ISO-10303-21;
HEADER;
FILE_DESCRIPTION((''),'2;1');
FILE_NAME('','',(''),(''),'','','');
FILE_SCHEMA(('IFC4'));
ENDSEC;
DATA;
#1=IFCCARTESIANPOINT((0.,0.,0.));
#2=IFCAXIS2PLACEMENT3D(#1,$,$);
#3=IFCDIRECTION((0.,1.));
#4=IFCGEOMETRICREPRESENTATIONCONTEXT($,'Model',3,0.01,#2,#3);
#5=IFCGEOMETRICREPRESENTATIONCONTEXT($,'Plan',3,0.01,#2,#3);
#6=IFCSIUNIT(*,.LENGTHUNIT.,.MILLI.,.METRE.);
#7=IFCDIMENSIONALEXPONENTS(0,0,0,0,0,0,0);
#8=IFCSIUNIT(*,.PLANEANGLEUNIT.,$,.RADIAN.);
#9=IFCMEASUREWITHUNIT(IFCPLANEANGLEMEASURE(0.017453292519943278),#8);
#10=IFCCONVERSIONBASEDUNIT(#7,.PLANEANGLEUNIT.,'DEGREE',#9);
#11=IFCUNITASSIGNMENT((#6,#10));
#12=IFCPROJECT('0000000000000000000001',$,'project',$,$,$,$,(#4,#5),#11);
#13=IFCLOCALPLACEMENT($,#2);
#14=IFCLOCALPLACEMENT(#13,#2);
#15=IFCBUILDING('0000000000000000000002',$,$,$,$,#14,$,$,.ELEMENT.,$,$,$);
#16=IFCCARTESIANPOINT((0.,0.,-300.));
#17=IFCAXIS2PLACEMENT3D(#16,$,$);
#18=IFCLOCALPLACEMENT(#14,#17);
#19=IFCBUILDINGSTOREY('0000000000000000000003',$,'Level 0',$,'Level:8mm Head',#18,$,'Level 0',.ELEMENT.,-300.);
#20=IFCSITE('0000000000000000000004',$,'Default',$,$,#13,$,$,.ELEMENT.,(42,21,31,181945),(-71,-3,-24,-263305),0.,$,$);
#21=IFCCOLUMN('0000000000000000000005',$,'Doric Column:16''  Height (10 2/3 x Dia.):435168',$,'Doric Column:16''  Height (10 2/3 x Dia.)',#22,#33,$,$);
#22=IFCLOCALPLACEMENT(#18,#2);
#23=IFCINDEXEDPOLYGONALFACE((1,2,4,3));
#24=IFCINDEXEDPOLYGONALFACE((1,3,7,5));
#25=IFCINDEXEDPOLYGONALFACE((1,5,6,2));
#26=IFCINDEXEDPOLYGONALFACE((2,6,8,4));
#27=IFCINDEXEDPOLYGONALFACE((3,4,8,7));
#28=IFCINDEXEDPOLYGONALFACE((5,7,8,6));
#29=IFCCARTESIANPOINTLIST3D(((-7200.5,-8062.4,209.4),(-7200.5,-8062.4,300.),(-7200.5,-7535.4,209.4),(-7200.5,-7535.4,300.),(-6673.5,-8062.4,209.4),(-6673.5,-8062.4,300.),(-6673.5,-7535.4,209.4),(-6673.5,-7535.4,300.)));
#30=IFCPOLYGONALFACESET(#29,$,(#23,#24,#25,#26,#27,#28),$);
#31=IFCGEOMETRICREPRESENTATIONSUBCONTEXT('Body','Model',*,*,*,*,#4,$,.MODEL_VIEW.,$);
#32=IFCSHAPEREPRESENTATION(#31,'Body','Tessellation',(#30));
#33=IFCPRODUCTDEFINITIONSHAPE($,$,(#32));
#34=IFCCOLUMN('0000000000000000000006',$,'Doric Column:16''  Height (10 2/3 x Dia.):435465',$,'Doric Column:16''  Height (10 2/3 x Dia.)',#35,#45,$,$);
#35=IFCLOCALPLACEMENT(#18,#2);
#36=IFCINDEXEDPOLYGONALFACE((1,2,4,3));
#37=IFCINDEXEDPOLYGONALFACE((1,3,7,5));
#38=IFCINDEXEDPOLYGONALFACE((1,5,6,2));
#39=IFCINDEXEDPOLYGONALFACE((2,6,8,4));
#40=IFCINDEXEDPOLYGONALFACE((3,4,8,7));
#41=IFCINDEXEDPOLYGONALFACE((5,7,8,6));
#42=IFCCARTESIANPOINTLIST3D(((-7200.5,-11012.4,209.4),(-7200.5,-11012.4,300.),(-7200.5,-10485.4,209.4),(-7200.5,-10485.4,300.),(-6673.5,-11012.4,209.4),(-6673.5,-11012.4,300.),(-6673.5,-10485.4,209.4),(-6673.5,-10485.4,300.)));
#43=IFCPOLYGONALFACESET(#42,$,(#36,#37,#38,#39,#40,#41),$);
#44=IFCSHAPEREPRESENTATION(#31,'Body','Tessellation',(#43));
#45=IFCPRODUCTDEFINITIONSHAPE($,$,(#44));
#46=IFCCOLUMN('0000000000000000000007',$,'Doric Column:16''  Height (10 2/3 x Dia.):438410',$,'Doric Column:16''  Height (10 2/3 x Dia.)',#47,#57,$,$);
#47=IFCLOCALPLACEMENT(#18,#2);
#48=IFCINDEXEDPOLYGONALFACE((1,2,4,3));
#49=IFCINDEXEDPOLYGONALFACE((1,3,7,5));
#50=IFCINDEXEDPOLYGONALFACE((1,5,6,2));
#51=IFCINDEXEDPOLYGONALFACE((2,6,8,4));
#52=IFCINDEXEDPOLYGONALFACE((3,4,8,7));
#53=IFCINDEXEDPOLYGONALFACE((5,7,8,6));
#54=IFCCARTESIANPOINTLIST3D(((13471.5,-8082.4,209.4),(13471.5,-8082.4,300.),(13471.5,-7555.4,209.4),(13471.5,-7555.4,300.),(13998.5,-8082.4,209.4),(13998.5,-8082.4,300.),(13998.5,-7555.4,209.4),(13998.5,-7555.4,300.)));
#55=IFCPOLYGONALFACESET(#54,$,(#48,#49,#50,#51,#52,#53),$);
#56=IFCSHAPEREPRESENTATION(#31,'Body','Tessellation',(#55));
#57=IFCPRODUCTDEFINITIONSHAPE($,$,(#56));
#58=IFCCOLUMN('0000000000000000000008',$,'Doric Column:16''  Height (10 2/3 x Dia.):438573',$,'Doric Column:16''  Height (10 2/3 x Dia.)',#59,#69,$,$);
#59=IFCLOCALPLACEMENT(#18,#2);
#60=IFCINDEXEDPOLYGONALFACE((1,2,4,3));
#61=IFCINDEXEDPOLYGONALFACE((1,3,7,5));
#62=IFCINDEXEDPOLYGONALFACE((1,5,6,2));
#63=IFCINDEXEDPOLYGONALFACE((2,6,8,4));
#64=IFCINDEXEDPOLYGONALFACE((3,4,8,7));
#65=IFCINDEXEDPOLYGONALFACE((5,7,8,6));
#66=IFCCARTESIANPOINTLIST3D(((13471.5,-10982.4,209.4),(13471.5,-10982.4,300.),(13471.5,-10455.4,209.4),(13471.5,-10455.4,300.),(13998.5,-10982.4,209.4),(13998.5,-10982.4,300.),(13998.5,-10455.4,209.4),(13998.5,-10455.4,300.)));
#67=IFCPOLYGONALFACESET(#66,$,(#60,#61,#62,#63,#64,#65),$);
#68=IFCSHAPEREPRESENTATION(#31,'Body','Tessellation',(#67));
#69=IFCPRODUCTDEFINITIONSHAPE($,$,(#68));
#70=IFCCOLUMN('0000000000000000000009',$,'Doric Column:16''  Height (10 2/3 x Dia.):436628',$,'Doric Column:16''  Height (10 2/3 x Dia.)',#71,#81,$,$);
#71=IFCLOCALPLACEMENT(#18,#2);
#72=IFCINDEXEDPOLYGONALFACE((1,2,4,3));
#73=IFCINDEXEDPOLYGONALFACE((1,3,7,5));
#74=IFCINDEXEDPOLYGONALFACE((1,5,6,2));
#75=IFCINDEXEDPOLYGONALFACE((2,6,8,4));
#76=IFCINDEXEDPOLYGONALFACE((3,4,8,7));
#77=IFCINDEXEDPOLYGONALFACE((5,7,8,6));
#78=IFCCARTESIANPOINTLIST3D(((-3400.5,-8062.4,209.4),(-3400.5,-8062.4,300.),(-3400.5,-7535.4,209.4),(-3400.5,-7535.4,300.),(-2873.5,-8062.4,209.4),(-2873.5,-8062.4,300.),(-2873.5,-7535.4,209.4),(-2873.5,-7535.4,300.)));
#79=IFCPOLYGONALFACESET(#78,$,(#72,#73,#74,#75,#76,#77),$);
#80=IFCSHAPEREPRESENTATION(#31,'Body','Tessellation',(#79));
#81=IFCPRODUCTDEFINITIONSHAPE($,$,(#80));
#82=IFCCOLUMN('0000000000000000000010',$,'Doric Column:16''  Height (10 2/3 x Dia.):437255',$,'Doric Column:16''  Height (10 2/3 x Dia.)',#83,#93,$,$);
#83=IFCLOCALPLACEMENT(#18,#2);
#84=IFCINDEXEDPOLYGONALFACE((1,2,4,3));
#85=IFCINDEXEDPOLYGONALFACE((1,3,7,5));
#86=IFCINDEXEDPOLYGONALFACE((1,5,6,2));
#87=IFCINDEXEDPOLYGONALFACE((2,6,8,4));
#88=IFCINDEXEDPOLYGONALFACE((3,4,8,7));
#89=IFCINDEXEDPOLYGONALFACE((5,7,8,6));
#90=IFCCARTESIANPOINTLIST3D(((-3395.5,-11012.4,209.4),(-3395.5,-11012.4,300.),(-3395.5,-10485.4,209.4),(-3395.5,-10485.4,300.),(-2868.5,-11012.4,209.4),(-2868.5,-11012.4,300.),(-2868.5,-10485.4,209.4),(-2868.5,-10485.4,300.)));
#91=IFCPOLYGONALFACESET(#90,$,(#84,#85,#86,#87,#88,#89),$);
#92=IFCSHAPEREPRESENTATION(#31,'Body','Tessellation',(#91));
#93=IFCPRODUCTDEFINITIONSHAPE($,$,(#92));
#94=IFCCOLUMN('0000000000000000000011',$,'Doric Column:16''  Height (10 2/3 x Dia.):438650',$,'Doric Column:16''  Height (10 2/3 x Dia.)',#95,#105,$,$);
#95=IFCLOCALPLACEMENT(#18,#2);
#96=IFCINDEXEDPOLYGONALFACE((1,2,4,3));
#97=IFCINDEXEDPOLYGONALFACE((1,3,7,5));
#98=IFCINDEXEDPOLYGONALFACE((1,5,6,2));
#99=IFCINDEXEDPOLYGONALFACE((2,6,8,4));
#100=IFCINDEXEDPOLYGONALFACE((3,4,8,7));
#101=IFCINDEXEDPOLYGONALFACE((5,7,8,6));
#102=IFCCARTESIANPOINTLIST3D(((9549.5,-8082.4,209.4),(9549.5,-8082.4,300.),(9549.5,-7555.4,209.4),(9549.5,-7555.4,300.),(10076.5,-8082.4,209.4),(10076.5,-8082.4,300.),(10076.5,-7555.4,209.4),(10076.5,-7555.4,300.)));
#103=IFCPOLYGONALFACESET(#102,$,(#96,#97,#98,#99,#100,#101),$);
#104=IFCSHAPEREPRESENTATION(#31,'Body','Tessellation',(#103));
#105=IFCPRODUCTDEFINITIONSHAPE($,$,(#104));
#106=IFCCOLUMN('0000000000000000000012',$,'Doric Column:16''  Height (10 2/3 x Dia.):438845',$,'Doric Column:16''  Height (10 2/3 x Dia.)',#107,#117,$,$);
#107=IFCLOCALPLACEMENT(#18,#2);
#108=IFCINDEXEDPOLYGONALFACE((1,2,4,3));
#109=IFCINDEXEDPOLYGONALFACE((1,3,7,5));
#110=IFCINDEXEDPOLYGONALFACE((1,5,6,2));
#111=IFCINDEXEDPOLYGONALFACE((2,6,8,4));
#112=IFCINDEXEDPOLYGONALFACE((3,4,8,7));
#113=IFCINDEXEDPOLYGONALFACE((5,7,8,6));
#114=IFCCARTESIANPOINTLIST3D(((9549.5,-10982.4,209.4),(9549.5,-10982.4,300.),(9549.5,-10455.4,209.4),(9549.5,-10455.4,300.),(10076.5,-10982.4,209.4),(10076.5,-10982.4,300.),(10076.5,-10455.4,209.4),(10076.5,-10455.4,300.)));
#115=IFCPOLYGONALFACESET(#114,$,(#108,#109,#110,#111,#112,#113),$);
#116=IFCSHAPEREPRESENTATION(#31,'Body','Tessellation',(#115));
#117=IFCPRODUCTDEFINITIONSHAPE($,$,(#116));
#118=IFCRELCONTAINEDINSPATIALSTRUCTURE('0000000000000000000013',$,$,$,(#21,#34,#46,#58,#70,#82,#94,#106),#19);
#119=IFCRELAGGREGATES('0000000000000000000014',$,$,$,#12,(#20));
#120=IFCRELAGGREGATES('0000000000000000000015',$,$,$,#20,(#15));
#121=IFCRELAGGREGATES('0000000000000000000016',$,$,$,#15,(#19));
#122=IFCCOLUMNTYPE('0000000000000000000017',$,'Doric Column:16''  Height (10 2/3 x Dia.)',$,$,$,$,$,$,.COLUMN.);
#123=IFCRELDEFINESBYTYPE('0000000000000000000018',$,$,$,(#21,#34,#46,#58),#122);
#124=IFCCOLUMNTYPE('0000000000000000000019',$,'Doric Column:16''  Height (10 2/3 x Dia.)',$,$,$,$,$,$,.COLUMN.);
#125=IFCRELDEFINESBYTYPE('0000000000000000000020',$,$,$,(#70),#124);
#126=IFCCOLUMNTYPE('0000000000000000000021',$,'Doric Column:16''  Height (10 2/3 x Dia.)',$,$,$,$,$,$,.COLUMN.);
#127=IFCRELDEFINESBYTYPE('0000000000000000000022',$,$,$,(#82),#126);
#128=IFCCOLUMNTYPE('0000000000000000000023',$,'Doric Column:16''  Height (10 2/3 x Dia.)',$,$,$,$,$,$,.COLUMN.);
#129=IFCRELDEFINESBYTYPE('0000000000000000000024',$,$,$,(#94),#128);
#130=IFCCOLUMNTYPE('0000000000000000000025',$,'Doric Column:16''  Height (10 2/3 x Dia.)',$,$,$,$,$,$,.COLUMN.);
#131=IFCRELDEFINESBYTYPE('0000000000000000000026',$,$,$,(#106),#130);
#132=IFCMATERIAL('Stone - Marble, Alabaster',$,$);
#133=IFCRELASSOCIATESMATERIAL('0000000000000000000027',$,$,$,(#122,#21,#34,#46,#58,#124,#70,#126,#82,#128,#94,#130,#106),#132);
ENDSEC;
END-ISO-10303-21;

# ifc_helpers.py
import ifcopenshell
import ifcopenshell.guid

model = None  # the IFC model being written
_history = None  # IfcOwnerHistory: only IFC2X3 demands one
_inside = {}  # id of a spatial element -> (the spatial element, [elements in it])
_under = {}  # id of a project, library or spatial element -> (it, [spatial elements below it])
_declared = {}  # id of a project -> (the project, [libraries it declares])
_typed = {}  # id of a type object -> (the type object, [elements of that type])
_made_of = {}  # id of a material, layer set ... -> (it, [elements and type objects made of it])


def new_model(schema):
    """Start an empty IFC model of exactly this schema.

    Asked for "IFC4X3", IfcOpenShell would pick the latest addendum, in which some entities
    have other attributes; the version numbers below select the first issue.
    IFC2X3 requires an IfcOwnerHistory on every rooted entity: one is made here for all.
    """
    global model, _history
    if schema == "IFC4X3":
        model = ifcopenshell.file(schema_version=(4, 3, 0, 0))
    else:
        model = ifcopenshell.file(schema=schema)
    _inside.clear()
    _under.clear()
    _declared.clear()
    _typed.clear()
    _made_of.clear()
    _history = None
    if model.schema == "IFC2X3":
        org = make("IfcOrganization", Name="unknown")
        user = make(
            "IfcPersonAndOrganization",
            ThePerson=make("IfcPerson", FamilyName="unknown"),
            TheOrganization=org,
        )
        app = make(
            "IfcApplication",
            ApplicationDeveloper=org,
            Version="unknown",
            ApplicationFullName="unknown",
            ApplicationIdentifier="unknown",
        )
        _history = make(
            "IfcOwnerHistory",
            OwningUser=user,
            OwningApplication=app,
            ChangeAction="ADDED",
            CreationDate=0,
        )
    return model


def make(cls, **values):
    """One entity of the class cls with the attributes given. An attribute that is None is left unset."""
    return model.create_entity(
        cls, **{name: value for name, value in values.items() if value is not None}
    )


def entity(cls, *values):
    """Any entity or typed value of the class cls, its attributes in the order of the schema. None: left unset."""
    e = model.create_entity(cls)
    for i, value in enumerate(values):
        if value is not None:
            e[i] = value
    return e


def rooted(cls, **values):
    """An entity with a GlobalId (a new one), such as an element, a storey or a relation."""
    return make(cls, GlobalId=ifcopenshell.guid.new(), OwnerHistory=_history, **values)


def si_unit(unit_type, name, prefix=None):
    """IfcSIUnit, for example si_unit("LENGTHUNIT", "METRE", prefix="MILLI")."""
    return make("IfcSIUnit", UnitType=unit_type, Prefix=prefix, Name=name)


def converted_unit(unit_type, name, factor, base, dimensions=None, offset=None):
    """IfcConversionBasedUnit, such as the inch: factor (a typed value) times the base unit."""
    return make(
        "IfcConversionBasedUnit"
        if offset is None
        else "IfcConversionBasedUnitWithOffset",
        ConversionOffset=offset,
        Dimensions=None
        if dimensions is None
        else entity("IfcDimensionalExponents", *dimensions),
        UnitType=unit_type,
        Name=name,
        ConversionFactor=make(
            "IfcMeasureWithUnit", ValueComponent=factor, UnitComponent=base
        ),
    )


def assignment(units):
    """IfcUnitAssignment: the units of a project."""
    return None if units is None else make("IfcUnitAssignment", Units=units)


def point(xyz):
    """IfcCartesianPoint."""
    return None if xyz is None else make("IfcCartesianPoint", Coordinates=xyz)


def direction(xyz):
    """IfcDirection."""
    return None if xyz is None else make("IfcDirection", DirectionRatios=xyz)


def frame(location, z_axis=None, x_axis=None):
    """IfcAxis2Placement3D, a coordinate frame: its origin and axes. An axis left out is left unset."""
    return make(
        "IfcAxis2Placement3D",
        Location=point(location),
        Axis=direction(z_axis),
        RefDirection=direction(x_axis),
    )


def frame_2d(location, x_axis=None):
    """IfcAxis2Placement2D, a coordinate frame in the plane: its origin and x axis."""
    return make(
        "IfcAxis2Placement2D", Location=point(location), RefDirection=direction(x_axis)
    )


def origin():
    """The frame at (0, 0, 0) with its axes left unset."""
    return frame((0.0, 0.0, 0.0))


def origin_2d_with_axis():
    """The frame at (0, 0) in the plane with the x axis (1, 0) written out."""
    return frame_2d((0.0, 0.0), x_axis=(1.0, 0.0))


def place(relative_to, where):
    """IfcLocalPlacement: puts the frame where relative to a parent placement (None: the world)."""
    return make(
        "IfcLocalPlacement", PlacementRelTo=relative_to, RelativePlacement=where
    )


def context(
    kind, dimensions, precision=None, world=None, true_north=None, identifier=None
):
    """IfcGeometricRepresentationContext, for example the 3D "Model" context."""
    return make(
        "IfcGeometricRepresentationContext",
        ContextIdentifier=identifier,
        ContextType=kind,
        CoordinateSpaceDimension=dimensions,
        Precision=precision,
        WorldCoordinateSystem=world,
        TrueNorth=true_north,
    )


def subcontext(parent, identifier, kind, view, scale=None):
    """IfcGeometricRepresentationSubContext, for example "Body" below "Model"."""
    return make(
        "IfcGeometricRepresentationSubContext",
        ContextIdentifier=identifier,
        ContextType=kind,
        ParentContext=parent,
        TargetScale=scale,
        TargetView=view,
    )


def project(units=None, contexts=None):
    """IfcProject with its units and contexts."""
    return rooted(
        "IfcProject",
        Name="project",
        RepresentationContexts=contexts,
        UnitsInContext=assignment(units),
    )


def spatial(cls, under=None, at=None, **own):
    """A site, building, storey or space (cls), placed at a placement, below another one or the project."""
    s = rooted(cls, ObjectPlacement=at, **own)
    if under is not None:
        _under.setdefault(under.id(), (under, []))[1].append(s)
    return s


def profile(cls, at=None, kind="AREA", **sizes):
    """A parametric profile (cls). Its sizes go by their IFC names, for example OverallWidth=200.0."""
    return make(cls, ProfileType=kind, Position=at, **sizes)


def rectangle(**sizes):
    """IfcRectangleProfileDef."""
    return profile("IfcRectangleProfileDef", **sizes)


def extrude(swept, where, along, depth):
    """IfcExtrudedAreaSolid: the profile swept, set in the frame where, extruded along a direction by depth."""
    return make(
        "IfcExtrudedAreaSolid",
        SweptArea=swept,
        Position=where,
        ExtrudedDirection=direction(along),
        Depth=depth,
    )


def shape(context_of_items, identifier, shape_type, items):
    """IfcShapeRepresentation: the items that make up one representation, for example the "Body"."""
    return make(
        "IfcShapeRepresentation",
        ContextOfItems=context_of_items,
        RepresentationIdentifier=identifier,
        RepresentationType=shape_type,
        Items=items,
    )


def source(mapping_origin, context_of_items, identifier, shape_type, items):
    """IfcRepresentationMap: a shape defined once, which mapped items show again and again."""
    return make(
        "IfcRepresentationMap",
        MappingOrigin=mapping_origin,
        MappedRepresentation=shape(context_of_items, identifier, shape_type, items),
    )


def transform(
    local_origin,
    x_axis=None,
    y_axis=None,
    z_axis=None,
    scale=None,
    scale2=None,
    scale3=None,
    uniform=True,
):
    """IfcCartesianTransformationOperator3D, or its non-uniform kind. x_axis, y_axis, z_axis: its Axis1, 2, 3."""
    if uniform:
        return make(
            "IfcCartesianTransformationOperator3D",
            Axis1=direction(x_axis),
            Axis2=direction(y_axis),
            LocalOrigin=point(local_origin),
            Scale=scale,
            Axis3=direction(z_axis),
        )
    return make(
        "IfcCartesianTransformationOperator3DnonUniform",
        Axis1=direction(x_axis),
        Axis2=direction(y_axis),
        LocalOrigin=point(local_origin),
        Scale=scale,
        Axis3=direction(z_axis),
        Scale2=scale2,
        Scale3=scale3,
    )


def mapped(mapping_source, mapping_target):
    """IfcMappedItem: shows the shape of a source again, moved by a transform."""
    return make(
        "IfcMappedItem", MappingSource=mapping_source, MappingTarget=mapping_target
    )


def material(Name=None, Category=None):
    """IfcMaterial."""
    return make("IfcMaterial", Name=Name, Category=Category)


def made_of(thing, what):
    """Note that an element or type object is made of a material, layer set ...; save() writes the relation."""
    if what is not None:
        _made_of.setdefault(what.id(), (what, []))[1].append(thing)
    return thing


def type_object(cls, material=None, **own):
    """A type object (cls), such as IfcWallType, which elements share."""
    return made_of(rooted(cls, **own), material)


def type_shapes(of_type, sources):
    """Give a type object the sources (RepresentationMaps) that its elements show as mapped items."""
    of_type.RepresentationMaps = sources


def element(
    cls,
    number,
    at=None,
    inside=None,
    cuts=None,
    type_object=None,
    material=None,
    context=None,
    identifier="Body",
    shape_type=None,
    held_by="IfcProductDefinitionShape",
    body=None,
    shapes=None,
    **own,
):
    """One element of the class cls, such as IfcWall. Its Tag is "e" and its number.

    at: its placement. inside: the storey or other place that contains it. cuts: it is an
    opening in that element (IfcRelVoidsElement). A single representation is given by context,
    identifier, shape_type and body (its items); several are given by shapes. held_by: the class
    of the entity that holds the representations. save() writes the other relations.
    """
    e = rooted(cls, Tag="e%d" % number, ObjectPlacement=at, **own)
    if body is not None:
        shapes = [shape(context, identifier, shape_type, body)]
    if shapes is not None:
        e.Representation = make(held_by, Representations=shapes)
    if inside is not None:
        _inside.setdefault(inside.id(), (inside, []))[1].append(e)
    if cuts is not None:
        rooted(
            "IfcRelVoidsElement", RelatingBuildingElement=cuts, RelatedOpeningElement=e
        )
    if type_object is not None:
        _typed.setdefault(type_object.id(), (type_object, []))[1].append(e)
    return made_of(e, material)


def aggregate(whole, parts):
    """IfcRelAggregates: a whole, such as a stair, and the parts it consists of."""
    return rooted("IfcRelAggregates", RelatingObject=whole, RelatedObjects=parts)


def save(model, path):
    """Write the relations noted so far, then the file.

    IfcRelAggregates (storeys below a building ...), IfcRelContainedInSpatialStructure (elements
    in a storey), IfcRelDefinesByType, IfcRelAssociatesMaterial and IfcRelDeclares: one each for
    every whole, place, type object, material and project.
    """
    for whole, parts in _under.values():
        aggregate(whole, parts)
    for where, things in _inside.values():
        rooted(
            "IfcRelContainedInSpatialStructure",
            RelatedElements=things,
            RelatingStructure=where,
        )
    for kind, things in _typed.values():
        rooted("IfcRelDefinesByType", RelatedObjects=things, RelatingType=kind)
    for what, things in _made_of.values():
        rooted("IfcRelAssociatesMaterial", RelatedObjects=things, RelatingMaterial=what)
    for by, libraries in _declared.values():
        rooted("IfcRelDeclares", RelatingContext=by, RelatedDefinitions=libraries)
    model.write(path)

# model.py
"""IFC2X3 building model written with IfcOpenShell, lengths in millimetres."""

from ifc_helpers import new_model, entity, si_unit, converted_unit, direction, frame, frame_2d, origin, origin_2d_with_axis, place, context, subcontext, project, spatial, rectangle, extrude, source, transform, mapped, material, type_object, type_shapes, element, save


model = new_model("IFC2X3")

# Units and contexts
model_context = context("Model", 3, precision=0.01, world=origin(), true_north=direction((0.0, 1.0)))
plan_context = context("Plan", 3, precision=0.01, world=origin(), true_north=direction((0.0, 1.0)))
body_context = subcontext(model_context, "Body", "Model", "MODEL_VIEW")
ifc_project = project(units=[si_unit("LENGTHUNIT", "METRE", prefix="MILLI"), converted_unit("PLANEANGLEUNIT", "DEGREE", entity("IfcPlaneAngleMeasure", 0.017453292519943278), si_unit("PLANEANGLEUNIT", "RADIAN"), dimensions=[0, 0, 0, 0, 0, 0, 0])], contexts=[model_context, plan_context])

# Site, building, storey
site_placement = place(None, origin())
site = spatial("IfcSite", under=ifc_project, at=site_placement, Name="Default", CompositionType="ELEMENT", RefLatitude=(42, 21, 31, 181945), RefLongitude=(-71, -3, -24, -263305), RefElevation=0.0)
building_placement = place(site_placement, origin())
building = spatial("IfcBuilding", under=site, at=building_placement, CompositionType="ELEMENT")
storey_placement = place(building_placement, frame((0.0, 0.0, -300.0)))
storey = spatial("IfcBuildingStorey", under=building, at=storey_placement, Name="Level 0", ObjectType="Level:8mm Head", LongName="Level 0", CompositionType="ELEMENT", Elevation=-300.0)

# Columns
ifc_material_1 = material(Name="Stone - Marble, Alabaster")
column_type_1 = type_object("IfcColumnType", Name="Doric Column:16'  Height (10 2/3 x Dia.)", PredefinedType="COLUMN", material=ifc_material_1)
shared_shape_1 = source(origin(), body_context, "Body", "SweptSolid", [
    extrude(rectangle(XDim=527.0, YDim=527.1, at=origin_2d_with_axis()), frame((0.0, 0.0, -90.6), z_axis=(0.0, 0.0, 1.0), x_axis=(-1.0, 0.0, 0.0)), (0.0, 0.0, 1.0), 90.6),
])
type_shapes(column_type_1, [shared_shape_1])
for number, where, name in (
    (1, (-6937.0, -7798.9, 300.0), "Doric Column:16'  Height (10 2/3 x Dia.):435168"),
    (2, (-6937.0, -10748.9, 300.0), "Doric Column:16'  Height (10 2/3 x Dia.):435465"),
    (3, (13735.0, -7818.9, 300.0), "Doric Column:16'  Height (10 2/3 x Dia.):438410"),
    (4, (13735.0, -10718.9, 300.0), "Doric Column:16'  Height (10 2/3 x Dia.):438573"),
):
    element("IfcColumn", number, at=place(storey_placement, frame(where)), inside=storey, type_object=column_type_1, material=ifc_material_1, Name=name, ObjectType="Doric Column:16'  Height (10 2/3 x Dia.)", context=body_context, shape_type="MappedRepresentation", body=[
        mapped(shared_shape_1, transform((0.0, 0.0, 0.0), scale=1.0)),
    ])
column_type_2 = type_object("IfcColumnType", Name="Doric Column:16'  Height (10 2/3 x Dia.)", PredefinedType="COLUMN", material=ifc_material_1)
shared_shape_2 = source(origin(), body_context, "Body", "SweptSolid", [
    extrude(rectangle(XDim=527.1, YDim=527.1, at=frame_2d((0.0, 0.0), x_axis=(1.0, 0.0))), frame((-3137.0, -7798.9, -90.6), z_axis=(0.0, 0.0, 1.0), x_axis=(-1.0, 0.0, 0.0)), (0.0, 0.0, 1.0), 90.6),
])
type_shapes(column_type_2, [shared_shape_2])
column_1_placement = place(storey_placement, frame((0.0, 0.0, 300.0)))
element("IfcColumn", 5, at=column_1_placement, inside=storey, type_object=column_type_2, material=ifc_material_1, Name="Doric Column:16'  Height (10 2/3 x Dia.):436628", ObjectType="Doric Column:16'  Height (10 2/3 x Dia.)", context=body_context, shape_type="MappedRepresentation", body=[
    mapped(shared_shape_2, transform((0.0, 0.0, 0.0), scale=1.0)),
])
column_type_3 = type_object("IfcColumnType", Name="Doric Column:16'  Height (10 2/3 x Dia.)", PredefinedType="COLUMN", material=ifc_material_1)
shared_shape_3 = source(origin(), body_context, "Body", "SweptSolid", [
    extrude(rectangle(XDim=527.1, YDim=527.1, at=origin_2d_with_axis()), frame((-3132.0, -10748.9, -90.6), z_axis=(0.0, 0.0, 1.0), x_axis=(-1.0, 0.0, 0.0)), (0.0, 0.0, 1.0), 90.6),
])
type_shapes(column_type_3, [shared_shape_3])
column_2_placement = place(storey_placement, frame((0.0, 0.0, 300.0)))
element("IfcColumn", 6, at=column_2_placement, inside=storey, type_object=column_type_3, material=ifc_material_1, Name="Doric Column:16'  Height (10 2/3 x Dia.):437255", ObjectType="Doric Column:16'  Height (10 2/3 x Dia.)", context=body_context, shape_type="MappedRepresentation", body=[
    mapped(shared_shape_3, transform((0.0, 0.0, 0.0), scale=1.0)),
])
column_type_4 = type_object("IfcColumnType", Name="Doric Column:16'  Height (10 2/3 x Dia.)", PredefinedType="COLUMN", material=ifc_material_1)
shared_shape_4 = source(origin(), body_context, "Body", "SweptSolid", [
    extrude(rectangle(XDim=527.1, YDim=527.1, at=frame_2d((0.0, 0.0), x_axis=(1.0, 0.0))), frame((9813.0, -7818.9, -90.6), z_axis=(0.0, 0.0, 1.0), x_axis=(-1.0, 0.0, 0.0)), (0.0, 0.0, 1.0), 90.6),
])
type_shapes(column_type_4, [shared_shape_4])
column_3_placement = place(storey_placement, frame((0.0, 0.0, 300.0)))
element("IfcColumn", 7, at=column_3_placement, inside=storey, type_object=column_type_4, material=ifc_material_1, Name="Doric Column:16'  Height (10 2/3 x Dia.):438650", ObjectType="Doric Column:16'  Height (10 2/3 x Dia.)", context=body_context, shape_type="MappedRepresentation", body=[
    mapped(shared_shape_4, transform((0.0, 0.0, 0.0), scale=1.0)),
])
column_type_5 = type_object("IfcColumnType", Name="Doric Column:16'  Height (10 2/3 x Dia.)", PredefinedType="COLUMN", material=ifc_material_1)
shared_shape_5 = source(origin(), body_context, "Body", "SweptSolid", [
    extrude(rectangle(XDim=527.1, YDim=527.0, at=frame_2d((0.0, 0.0), x_axis=(1.0, 0.0))), frame((9813.0, -10718.9, -90.6), z_axis=(0.0, 0.0, 1.0), x_axis=(-1.0, 0.0, 0.0)), (0.0, 0.0, 1.0), 90.6),
])
type_shapes(column_type_5, [shared_shape_5])
column_4_placement = place(storey_placement, frame((0.0, 0.0, 300.0)))
element("IfcColumn", 8, at=column_4_placement, inside=storey, type_object=column_type_5, material=ifc_material_1, Name="Doric Column:16'  Height (10 2/3 x Dia.):438845", ObjectType="Doric Column:16'  Height (10 2/3 x Dia.)", context=body_context, shape_type="MappedRepresentation", body=[
    mapped(shared_shape_5, transform((0.0, 0.0, 0.0), scale=1.0)),
])

save(model, "model.ifc")
